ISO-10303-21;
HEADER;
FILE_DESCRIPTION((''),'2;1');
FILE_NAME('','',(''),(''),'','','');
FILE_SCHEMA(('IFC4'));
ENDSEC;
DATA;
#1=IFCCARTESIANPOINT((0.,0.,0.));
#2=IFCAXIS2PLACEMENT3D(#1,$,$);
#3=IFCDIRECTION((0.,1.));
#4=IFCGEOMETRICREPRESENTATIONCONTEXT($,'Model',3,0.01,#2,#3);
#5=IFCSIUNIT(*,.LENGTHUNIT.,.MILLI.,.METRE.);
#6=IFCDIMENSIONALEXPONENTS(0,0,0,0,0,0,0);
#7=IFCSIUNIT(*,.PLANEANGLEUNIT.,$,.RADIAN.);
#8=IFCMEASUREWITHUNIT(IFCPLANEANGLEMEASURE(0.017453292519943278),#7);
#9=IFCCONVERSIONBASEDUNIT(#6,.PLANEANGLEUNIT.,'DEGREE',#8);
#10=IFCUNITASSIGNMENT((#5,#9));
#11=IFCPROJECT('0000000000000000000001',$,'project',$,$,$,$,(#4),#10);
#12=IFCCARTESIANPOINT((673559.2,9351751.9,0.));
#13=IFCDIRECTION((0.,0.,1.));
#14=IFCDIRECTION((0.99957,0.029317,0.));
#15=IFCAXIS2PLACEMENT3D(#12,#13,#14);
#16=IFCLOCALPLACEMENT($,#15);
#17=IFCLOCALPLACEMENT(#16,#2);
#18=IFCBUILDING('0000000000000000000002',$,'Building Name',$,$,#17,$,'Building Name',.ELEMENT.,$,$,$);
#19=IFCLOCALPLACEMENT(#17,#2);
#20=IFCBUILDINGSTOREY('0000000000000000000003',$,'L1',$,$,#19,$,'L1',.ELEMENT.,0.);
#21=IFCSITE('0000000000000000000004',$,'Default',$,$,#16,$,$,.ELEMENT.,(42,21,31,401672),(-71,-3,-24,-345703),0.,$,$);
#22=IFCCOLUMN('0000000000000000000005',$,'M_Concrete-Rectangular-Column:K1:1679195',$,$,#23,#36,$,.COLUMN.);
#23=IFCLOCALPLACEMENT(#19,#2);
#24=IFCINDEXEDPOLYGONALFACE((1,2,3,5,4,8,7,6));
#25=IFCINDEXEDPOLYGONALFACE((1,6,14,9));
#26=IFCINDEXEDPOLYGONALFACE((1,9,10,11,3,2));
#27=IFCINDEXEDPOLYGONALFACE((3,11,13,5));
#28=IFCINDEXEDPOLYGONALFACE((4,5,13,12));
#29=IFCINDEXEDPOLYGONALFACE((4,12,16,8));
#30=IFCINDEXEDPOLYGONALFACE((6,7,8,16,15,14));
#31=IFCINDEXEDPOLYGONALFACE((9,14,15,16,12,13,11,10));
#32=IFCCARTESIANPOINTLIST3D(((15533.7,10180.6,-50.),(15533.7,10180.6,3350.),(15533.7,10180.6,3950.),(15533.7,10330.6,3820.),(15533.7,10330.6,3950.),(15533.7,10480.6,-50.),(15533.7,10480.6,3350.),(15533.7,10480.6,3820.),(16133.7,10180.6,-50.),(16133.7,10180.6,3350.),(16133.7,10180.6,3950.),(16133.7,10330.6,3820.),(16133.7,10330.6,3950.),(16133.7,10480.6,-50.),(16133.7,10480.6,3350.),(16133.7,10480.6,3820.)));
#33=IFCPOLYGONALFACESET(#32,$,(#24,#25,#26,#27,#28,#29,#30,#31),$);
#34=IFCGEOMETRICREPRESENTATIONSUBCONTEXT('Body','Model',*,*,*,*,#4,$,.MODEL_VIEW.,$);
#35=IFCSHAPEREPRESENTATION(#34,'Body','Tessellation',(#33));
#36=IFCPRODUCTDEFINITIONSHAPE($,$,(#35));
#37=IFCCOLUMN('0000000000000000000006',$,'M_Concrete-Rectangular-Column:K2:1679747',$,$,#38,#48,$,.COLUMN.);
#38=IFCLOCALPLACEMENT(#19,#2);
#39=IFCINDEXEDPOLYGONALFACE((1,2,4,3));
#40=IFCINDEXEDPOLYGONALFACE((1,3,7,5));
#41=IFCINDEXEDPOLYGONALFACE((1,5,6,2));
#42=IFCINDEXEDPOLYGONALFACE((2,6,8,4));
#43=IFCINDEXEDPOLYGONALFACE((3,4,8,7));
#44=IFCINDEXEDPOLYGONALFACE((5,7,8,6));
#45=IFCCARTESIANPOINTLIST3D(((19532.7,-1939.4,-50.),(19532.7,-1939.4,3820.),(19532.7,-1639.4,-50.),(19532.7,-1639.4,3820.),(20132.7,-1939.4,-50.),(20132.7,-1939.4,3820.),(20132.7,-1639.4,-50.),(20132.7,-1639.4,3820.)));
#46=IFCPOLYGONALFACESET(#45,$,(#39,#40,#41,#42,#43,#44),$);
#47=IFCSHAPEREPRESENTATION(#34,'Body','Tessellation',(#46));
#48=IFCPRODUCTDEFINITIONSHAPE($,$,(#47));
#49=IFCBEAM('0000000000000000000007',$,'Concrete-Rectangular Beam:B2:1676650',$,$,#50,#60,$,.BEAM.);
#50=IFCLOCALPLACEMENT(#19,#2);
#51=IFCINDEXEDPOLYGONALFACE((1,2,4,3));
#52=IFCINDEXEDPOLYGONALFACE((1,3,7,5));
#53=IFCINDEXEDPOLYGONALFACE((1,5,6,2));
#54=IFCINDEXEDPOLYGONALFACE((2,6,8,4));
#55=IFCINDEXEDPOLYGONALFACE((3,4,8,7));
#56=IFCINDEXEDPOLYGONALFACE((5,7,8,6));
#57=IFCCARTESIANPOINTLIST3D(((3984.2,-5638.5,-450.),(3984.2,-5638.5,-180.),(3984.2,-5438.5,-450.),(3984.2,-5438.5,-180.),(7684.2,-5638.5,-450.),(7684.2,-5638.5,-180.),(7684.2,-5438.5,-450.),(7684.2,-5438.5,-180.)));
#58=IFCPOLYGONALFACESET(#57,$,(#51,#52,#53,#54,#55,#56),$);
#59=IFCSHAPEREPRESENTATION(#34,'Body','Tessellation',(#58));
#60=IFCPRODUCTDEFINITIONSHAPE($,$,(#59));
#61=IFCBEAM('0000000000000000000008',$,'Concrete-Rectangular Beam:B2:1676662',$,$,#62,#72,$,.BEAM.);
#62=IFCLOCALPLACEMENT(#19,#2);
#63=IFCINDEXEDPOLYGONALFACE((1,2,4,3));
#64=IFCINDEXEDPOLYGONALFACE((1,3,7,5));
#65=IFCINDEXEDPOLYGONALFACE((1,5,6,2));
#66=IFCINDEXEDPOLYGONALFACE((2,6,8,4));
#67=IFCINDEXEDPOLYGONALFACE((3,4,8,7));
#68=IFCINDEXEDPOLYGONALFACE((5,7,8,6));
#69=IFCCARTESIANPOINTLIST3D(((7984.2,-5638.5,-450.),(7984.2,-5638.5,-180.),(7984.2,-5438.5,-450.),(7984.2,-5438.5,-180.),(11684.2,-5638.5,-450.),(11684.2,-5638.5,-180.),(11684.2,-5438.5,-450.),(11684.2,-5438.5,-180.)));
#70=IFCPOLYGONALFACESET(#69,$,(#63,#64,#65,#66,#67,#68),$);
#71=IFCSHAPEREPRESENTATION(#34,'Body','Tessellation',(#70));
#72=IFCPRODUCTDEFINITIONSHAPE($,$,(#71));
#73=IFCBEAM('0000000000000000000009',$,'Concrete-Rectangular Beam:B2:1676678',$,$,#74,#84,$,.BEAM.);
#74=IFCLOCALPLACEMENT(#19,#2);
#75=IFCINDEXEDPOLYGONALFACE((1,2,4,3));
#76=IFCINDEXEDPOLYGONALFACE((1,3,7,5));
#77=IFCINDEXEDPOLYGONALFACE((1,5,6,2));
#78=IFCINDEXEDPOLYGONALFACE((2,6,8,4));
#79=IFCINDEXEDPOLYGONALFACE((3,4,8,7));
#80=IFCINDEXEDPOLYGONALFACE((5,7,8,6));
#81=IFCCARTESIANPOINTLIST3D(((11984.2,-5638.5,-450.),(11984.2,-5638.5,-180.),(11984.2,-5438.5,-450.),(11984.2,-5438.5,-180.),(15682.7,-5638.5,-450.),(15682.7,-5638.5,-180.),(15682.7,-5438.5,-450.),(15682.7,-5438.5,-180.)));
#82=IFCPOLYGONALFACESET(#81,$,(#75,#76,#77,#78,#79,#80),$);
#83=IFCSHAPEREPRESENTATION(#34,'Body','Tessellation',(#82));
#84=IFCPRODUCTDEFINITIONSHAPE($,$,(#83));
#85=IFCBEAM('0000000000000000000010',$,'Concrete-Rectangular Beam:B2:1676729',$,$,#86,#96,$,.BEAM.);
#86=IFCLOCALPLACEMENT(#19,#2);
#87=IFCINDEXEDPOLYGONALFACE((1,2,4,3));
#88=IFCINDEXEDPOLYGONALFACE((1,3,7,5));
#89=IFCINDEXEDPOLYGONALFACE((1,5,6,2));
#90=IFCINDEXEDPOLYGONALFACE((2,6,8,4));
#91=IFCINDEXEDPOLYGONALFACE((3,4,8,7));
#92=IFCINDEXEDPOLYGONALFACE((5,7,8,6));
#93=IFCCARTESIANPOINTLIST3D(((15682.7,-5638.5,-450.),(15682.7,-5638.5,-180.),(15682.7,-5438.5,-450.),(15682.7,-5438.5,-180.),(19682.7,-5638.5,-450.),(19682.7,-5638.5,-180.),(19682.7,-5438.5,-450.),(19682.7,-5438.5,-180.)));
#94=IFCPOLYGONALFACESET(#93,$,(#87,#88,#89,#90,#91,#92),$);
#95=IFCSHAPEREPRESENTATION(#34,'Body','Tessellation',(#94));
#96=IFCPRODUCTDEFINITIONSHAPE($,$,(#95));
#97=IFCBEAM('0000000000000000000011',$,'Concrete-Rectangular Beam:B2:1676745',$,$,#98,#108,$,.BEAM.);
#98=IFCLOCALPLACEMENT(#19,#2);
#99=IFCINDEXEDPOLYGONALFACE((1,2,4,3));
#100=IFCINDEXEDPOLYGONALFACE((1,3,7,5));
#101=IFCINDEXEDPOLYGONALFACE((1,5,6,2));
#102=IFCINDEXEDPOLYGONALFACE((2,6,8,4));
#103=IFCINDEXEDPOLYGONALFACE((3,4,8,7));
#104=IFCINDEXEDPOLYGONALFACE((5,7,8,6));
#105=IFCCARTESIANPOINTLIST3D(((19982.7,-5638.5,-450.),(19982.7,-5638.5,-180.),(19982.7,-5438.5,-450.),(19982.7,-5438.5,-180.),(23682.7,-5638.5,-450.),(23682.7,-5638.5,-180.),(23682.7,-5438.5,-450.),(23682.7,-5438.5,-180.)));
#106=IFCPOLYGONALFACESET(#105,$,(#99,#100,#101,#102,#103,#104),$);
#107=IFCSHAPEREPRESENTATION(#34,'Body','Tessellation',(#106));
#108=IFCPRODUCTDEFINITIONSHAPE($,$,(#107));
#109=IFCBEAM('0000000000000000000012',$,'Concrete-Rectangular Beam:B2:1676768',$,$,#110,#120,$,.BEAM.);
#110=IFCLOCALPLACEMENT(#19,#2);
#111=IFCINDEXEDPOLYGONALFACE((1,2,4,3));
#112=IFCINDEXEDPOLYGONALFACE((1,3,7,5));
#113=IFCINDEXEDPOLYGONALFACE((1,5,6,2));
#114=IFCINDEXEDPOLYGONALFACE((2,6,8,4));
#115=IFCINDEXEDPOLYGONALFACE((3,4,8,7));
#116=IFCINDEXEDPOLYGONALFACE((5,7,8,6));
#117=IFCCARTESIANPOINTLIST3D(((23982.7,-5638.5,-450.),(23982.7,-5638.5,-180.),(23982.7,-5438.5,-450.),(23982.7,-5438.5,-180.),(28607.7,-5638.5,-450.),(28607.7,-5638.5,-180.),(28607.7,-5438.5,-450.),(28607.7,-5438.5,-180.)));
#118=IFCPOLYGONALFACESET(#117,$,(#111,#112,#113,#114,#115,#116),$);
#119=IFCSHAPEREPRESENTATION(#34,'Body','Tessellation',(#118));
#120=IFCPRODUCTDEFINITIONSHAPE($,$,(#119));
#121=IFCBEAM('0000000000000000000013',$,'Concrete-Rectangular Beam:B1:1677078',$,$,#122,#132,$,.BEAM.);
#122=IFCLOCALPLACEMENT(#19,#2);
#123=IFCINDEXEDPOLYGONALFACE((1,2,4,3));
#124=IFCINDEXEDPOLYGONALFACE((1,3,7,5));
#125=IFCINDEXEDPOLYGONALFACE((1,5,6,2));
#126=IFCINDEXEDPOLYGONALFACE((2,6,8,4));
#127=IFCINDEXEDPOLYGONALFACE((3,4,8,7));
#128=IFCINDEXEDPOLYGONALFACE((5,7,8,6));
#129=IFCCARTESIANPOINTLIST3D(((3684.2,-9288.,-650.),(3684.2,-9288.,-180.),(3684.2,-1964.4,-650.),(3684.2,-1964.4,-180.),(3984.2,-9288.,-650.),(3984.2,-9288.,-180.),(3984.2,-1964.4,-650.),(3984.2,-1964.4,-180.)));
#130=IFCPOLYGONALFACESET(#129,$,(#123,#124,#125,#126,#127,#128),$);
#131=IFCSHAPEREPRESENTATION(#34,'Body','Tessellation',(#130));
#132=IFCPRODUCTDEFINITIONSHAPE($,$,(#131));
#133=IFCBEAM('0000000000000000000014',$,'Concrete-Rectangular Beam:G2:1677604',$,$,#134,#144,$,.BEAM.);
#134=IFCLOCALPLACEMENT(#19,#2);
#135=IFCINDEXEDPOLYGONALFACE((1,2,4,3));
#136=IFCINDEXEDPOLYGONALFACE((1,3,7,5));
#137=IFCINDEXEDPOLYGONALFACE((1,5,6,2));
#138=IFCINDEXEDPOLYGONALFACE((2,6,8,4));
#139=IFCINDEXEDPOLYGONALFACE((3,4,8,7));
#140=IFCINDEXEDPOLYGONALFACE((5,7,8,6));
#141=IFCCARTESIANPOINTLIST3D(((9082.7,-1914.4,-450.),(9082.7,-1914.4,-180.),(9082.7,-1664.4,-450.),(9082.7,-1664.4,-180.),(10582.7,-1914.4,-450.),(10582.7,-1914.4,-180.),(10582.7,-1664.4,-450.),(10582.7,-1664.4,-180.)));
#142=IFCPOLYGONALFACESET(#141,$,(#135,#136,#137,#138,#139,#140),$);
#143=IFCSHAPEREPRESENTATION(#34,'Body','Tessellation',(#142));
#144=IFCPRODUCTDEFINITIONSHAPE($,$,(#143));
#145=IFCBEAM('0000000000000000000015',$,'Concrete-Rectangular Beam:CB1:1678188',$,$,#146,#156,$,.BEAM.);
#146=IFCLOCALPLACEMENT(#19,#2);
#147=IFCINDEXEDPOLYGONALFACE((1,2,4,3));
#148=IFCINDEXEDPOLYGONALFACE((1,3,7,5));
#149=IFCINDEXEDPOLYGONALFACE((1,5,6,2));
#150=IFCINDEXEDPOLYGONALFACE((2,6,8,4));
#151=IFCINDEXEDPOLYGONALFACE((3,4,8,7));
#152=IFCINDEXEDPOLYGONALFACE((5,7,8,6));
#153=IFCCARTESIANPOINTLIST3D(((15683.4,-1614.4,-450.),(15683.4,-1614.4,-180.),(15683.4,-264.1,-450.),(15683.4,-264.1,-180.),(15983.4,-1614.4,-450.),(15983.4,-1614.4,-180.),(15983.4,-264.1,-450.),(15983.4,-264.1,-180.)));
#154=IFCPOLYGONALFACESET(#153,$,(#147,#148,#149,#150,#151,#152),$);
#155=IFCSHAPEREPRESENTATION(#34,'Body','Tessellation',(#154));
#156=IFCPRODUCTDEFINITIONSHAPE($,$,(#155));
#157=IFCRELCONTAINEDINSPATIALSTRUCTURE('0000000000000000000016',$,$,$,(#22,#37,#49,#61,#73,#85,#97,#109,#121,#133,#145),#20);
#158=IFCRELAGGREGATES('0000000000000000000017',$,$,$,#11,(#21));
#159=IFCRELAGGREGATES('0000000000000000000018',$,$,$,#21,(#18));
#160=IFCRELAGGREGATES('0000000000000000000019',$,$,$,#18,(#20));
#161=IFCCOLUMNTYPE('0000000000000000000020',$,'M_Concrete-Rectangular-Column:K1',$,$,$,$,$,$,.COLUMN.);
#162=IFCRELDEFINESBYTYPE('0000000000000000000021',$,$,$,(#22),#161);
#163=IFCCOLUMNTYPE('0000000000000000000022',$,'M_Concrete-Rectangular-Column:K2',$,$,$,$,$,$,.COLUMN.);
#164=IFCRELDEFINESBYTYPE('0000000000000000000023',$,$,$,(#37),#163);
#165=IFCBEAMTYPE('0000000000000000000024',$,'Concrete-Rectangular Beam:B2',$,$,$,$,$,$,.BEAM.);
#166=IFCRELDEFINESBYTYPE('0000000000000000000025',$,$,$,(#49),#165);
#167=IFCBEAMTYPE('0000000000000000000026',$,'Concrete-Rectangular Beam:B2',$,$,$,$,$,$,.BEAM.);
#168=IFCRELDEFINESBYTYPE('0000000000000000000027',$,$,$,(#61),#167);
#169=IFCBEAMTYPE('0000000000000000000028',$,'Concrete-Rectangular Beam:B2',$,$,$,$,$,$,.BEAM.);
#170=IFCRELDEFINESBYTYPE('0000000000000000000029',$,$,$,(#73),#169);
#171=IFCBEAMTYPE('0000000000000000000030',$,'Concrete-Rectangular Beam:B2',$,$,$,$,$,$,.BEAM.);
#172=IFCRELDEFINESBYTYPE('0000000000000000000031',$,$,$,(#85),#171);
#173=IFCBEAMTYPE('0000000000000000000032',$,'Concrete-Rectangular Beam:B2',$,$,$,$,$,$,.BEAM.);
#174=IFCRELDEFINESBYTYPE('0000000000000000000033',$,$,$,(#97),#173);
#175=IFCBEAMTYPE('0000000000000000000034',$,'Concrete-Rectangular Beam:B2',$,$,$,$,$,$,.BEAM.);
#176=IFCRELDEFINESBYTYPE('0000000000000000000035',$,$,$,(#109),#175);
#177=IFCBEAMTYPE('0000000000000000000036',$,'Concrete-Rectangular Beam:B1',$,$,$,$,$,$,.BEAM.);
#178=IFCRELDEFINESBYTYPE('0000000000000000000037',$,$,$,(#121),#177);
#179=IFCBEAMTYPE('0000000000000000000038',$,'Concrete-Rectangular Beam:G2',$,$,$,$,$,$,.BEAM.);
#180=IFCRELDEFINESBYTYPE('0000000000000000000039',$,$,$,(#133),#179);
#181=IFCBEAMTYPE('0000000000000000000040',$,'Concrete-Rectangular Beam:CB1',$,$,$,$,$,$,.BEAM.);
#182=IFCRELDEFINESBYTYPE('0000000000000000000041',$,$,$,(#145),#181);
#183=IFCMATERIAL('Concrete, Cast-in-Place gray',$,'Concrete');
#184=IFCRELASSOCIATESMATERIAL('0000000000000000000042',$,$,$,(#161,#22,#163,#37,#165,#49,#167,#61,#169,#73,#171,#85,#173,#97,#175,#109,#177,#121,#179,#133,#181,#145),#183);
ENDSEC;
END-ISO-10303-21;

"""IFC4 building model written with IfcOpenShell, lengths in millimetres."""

from ifc_helpers import new_model, entity, si_unit, converted_unit, direction, frame, origin, place, context, subcontext, project, spatial, indexed_curve, outline, extrude, source, transform, mapped, material, type_object, type_shapes, element, save


model = new_model("IFC4")

# Units and contexts
model_context = context("Model", 3, precision=0.01, world=origin(), true_north=direction((0.0, 1.0)))
body_context = subcontext(model_context, "Body", "Model", "MODEL_VIEW")
ifc_project = project(units=[si_unit("LENGTHUNIT", "METRE", prefix="MILLI"), converted_unit("PLANEANGLEUNIT", "DEGREE", entity("IfcPlaneAngleMeasure", 0.017453292519943278), si_unit("PLANEANGLEUNIT", "RADIAN"), dimensions=[0, 0, 0, 0, 0, 0, 0])], contexts=[model_context])

# Site, building, storey
site_placement = place(None, frame((673559.2, 9351751.9, 0.0), z_axis=(0.0, 0.0, 1.0), x_axis=(0.99957, 0.029317, 0.0)))
site = spatial("IfcSite", under=ifc_project, at=site_placement, Name="Default", CompositionType="ELEMENT", RefLatitude=(42, 21, 31, 401672), RefLongitude=(-71, -3, -24, -345703), RefElevation=0.0)
building_placement = place(site_placement, origin())
building = spatial("IfcBuilding", under=site, at=building_placement, Name="Building Name", LongName="Building Name", CompositionType="ELEMENT")
storey_placement = place(building_placement, origin())
storey = spatial("IfcBuildingStorey", under=building, at=storey_placement, Name="L1", LongName="L1", CompositionType="ELEMENT", Elevation=0.0)

# Columns
ifc_material_1 = material(Name="Concrete, Cast-in-Place gray", Category="Concrete")
column_type_1 = type_object("IfcColumnType", Name="M_Concrete-Rectangular-Column:K1", PredefinedType="COLUMN", material=ifc_material_1)
shared_shape_1 = source(origin(), body_context, "Body", "SweptSolid", [
    extrude(outline(indexed_curve([(-2817.5, -150.0), (582.5, -150.0), (1052.5, -150.0), (1052.5, 0.0), (1182.5, 0.0), (1182.5, 150.0), (582.5, 150.0), (-2817.5, 150.0), (-2817.5, -150.0)], self_intersect=False)), frame((15533.7, 10330.6, 2767.5), z_axis=(1.0, 0.0, 0.0), x_axis=(0.0, 0.0, 1.0)), (0.0, 0.0, 1.0), 600.0),
])
type_shapes(column_type_1, [shared_shape_1])
column_1_placement = place(storey_placement, origin())
element("IfcColumn", 1, at=column_1_placement, inside=storey, type_object=column_type_1, material=ifc_material_1, Name="M_Concrete-Rectangular-Column:K1:1679195", PredefinedType="COLUMN", context=body_context, shape_type="MappedRepresentation", body=[
    mapped(shared_shape_1, transform((0.0, 0.0, 0.0), scale=1.0)),
])
column_type_2 = type_object("IfcColumnType", Name="M_Concrete-Rectangular-Column:K2", PredefinedType="COLUMN", material=ifc_material_1)
shared_shape_2 = source(origin(), body_context, "Body", "SweptSolid", [
    extrude(outline(indexed_curve([(-150.0, -300.0), (150.0, -300.0), (150.0, 300.0), (-150.0, 300.0), (-150.0, -300.0)], self_intersect=False)), frame((19832.7, -1789.4, -50.0), z_axis=(0.0, 0.0, 1.0), x_axis=(0.0, -1.0, 0.0)), (0.0, 0.0, 1.0), 3870.0),
])
type_shapes(column_type_2, [shared_shape_2])
column_2_placement = place(storey_placement, origin())
element("IfcColumn", 2, at=column_2_placement, inside=storey, type_object=column_type_2, material=ifc_material_1, Name="M_Concrete-Rectangular-Column:K2:1679747", PredefinedType="COLUMN", context=body_context, shape_type="MappedRepresentation", body=[
    mapped(shared_shape_2, transform((0.0, 0.0, 0.0), scale=1.0)),
])

# Beams
beam_type_1 = type_object("IfcBeamType", Name="Concrete-Rectangular Beam:B2", PredefinedType="BEAM", material=ifc_material_1)
shared_shape_3 = source(origin(), body_context, "Body", "SweptSolid", [
    extrude(outline(indexed_curve([(-135.0, -100.0), (135.0, -100.0), (135.0, 100.0), (-135.0, 100.0), (-135.0, -100.0)], self_intersect=False)), frame((3984.2, -5538.5, -315.0), z_axis=(1.0, 0.0, 0.0), x_axis=(0.0, 0.0, -1.0)), (0.0, 0.0, 1.0), 3700.0),
])
type_shapes(beam_type_1, [shared_shape_3])
beam_1_placement = place(storey_placement, origin())
element("IfcBeam", 3, at=beam_1_placement, inside=storey, type_object=beam_type_1, material=ifc_material_1, Name="Concrete-Rectangular Beam:B2:1676650", PredefinedType="BEAM", context=body_context, shape_type="MappedRepresentation", body=[
    mapped(shared_shape_3, transform((0.0, 0.0, 0.0), scale=1.0)),
])
beam_type_2 = type_object("IfcBeamType", Name="Concrete-Rectangular Beam:B2", PredefinedType="BEAM", material=ifc_material_1)
shared_shape_4 = source(origin(), body_context, "Body", "SweptSolid", [
    extrude(outline(indexed_curve([(-135.0, -100.0), (135.0, -100.0), (135.0, 100.0), (-135.0, 100.0), (-135.0, -100.0)], self_intersect=False)), frame((7984.2, -5538.5, -315.0), z_axis=(1.0, 0.0, 0.0), x_axis=(0.0, 0.0, -1.0)), (0.0, 0.0, 1.0), 3700.0),
])
type_shapes(beam_type_2, [shared_shape_4])
beam_2_placement = place(storey_placement, origin())
element("IfcBeam", 4, at=beam_2_placement, inside=storey, type_object=beam_type_2, material=ifc_material_1, Name="Concrete-Rectangular Beam:B2:1676662", PredefinedType="BEAM", context=body_context, shape_type="MappedRepresentation", body=[
    mapped(shared_shape_4, transform((0.0, 0.0, 0.0), scale=1.0)),
])
beam_type_3 = type_object("IfcBeamType", Name="Concrete-Rectangular Beam:B2", PredefinedType="BEAM", material=ifc_material_1)
shared_shape_5 = source(origin(), body_context, "Body", "SweptSolid", [
    extrude(outline(indexed_curve([(-135.0, -100.0), (135.0, -100.0), (135.0, 100.0), (-135.0, 100.0), (-135.0, -100.0)], self_intersect=False)), frame((11984.2, -5538.5, -315.0), z_axis=(1.0, 0.0, 0.0), x_axis=(0.0, 0.0, -1.0)), (0.0, 0.0, 1.0), 3698.5),
])
type_shapes(beam_type_3, [shared_shape_5])
beam_3_placement = place(storey_placement, origin())
element("IfcBeam", 5, at=beam_3_placement, inside=storey, type_object=beam_type_3, material=ifc_material_1, Name="Concrete-Rectangular Beam:B2:1676678", PredefinedType="BEAM", context=body_context, shape_type="MappedRepresentation", body=[
    mapped(shared_shape_5, transform((0.0, 0.0, 0.0), scale=1.0)),
])
beam_type_4 = type_object("IfcBeamType", Name="Concrete-Rectangular Beam:B2", PredefinedType="BEAM", material=ifc_material_1)
shared_shape_6 = source(origin(), body_context, "Body", "SweptSolid", [
    extrude(outline(indexed_curve([(-135.0, -100.0), (135.0, -100.0), (135.0, 100.0), (-135.0, 100.0), (-135.0, -100.0)], self_intersect=False)), frame((15682.7, -5538.5, -315.0), z_axis=(1.0, 0.0, 0.0), x_axis=(0.0, 0.0, -1.0)), (0.0, 0.0, 1.0), 4000.0),
])
type_shapes(beam_type_4, [shared_shape_6])
beam_4_placement = place(storey_placement, origin())
element("IfcBeam", 6, at=beam_4_placement, inside=storey, type_object=beam_type_4, material=ifc_material_1, Name="Concrete-Rectangular Beam:B2:1676729", PredefinedType="BEAM", context=body_context, shape_type="MappedRepresentation", body=[
    mapped(shared_shape_6, transform((0.0, 0.0, 0.0), scale=1.0)),
])
beam_type_5 = type_object("IfcBeamType", Name="Concrete-Rectangular Beam:B2", PredefinedType="BEAM", material=ifc_material_1)
shared_shape_7 = source(origin(), body_context, "Body", "SweptSolid", [
    extrude(outline(indexed_curve([(-135.0, -100.0), (135.0, -100.0), (135.0, 100.0), (-135.0, 100.0), (-135.0, -100.0)], self_intersect=False)), frame((19982.7, -5538.5, -315.0), z_axis=(1.0, 0.0, 0.0), x_axis=(0.0, 0.0, -1.0)), (0.0, 0.0, 1.0), 3700.0),
])
type_shapes(beam_type_5, [shared_shape_7])
beam_5_placement = place(storey_placement, origin())
element("IfcBeam", 7, at=beam_5_placement, inside=storey, type_object=beam_type_5, material=ifc_material_1, Name="Concrete-Rectangular Beam:B2:1676745", PredefinedType="BEAM", context=body_context, shape_type="MappedRepresentation", body=[
    mapped(shared_shape_7, transform((0.0, 0.0, 0.0), scale=1.0)),
])
beam_type_6 = type_object("IfcBeamType", Name="Concrete-Rectangular Beam:B2", PredefinedType="BEAM", material=ifc_material_1)
shared_shape_8 = source(origin(), body_context, "Body", "SweptSolid", [
    extrude(outline(indexed_curve([(-135.0, -100.0), (135.0, -100.0), (135.0, 100.0), (-135.0, 100.0), (-135.0, -100.0)], self_intersect=False)), frame((23982.7, -5538.5, -315.0), z_axis=(1.0, 0.0, 0.0), x_axis=(0.0, 0.0, -1.0)), (0.0, 0.0, 1.0), 4625.0),
])
type_shapes(beam_type_6, [shared_shape_8])
beam_6_placement = place(storey_placement, origin())
element("IfcBeam", 8, at=beam_6_placement, inside=storey, type_object=beam_type_6, material=ifc_material_1, Name="Concrete-Rectangular Beam:B2:1676768", PredefinedType="BEAM", context=body_context, shape_type="MappedRepresentation", body=[
    mapped(shared_shape_8, transform((0.0, 0.0, 0.0), scale=1.0)),
])
beam_type_7 = type_object("IfcBeamType", Name="Concrete-Rectangular Beam:B1", PredefinedType="BEAM", material=ifc_material_1)
shared_shape_9 = source(origin(), body_context, "Body", "SweptSolid", [
    extrude(outline(indexed_curve([(-150.0, -235.0), (150.0, -235.0), (150.0, 235.0), (-150.0, 235.0), (-150.0, -235.0)], self_intersect=False)), frame((3834.2, -9288.0, -415.0), z_axis=(0.0, 1.0, 0.0), x_axis=(-1.0, 0.0, 0.0)), (0.0, 0.0, 1.0), 7323.6),
])
type_shapes(beam_type_7, [shared_shape_9])
beam_7_placement = place(storey_placement, origin())
element("IfcBeam", 9, at=beam_7_placement, inside=storey, type_object=beam_type_7, material=ifc_material_1, Name="Concrete-Rectangular Beam:B1:1677078", PredefinedType="BEAM", context=body_context, shape_type="MappedRepresentation", body=[
    mapped(shared_shape_9, transform((0.0, 0.0, 0.0), scale=1.0)),
])
beam_type_8 = type_object("IfcBeamType", Name="Concrete-Rectangular Beam:G2", PredefinedType="BEAM", material=ifc_material_1)
shared_shape_10 = source(origin(), body_context, "Body", "SweptSolid", [
    extrude(outline(indexed_curve([(-135.0, -125.0), (135.0, -125.0), (135.0, 125.0), (-135.0, 125.0), (-135.0, -125.0)], self_intersect=False)), frame((9082.7, -1789.4, -315.0), z_axis=(1.0, 0.0, 0.0), x_axis=(0.0, 0.0, -1.0)), (0.0, 0.0, 1.0), 1500.0),
])
type_shapes(beam_type_8, [shared_shape_10])
beam_8_placement = place(storey_placement, origin())
element("IfcBeam", 10, at=beam_8_placement, inside=storey, type_object=beam_type_8, material=ifc_material_1, Name="Concrete-Rectangular Beam:G2:1677604", PredefinedType="BEAM", context=body_context, shape_type="MappedRepresentation", body=[
    mapped(shared_shape_10, transform((0.0, 0.0, 0.0), scale=1.0)),
])
beam_type_9 = type_object("IfcBeamType", Name="Concrete-Rectangular Beam:CB1", PredefinedType="BEAM", material=ifc_material_1)
shared_shape_11 = source(origin(), body_context, "Body", "SweptSolid", [
    extrude(outline(indexed_curve([(-150.0, -135.0), (150.0, -135.0), (150.0, 135.0), (-150.0, 135.0), (-150.0, -135.0)], self_intersect=False)), frame((15833.4, -1614.4, -315.0), z_axis=(0.0, 1.0, 0.0), x_axis=(-1.0, 0.0, 0.0)), (0.0, 0.0, 1.0), 1350.4),
])
type_shapes(beam_type_9, [shared_shape_11])
beam_9_placement = place(storey_placement, origin())
element("IfcBeam", 11, at=beam_9_placement, inside=storey, type_object=beam_type_9, material=ifc_material_1, Name="Concrete-Rectangular Beam:CB1:1678188", PredefinedType="BEAM", context=body_context, shape_type="MappedRepresentation", body=[
    mapped(shared_shape_11, transform((0.0, 0.0, 0.0), scale=1.0)),
])

save(model, "model.ifc")
